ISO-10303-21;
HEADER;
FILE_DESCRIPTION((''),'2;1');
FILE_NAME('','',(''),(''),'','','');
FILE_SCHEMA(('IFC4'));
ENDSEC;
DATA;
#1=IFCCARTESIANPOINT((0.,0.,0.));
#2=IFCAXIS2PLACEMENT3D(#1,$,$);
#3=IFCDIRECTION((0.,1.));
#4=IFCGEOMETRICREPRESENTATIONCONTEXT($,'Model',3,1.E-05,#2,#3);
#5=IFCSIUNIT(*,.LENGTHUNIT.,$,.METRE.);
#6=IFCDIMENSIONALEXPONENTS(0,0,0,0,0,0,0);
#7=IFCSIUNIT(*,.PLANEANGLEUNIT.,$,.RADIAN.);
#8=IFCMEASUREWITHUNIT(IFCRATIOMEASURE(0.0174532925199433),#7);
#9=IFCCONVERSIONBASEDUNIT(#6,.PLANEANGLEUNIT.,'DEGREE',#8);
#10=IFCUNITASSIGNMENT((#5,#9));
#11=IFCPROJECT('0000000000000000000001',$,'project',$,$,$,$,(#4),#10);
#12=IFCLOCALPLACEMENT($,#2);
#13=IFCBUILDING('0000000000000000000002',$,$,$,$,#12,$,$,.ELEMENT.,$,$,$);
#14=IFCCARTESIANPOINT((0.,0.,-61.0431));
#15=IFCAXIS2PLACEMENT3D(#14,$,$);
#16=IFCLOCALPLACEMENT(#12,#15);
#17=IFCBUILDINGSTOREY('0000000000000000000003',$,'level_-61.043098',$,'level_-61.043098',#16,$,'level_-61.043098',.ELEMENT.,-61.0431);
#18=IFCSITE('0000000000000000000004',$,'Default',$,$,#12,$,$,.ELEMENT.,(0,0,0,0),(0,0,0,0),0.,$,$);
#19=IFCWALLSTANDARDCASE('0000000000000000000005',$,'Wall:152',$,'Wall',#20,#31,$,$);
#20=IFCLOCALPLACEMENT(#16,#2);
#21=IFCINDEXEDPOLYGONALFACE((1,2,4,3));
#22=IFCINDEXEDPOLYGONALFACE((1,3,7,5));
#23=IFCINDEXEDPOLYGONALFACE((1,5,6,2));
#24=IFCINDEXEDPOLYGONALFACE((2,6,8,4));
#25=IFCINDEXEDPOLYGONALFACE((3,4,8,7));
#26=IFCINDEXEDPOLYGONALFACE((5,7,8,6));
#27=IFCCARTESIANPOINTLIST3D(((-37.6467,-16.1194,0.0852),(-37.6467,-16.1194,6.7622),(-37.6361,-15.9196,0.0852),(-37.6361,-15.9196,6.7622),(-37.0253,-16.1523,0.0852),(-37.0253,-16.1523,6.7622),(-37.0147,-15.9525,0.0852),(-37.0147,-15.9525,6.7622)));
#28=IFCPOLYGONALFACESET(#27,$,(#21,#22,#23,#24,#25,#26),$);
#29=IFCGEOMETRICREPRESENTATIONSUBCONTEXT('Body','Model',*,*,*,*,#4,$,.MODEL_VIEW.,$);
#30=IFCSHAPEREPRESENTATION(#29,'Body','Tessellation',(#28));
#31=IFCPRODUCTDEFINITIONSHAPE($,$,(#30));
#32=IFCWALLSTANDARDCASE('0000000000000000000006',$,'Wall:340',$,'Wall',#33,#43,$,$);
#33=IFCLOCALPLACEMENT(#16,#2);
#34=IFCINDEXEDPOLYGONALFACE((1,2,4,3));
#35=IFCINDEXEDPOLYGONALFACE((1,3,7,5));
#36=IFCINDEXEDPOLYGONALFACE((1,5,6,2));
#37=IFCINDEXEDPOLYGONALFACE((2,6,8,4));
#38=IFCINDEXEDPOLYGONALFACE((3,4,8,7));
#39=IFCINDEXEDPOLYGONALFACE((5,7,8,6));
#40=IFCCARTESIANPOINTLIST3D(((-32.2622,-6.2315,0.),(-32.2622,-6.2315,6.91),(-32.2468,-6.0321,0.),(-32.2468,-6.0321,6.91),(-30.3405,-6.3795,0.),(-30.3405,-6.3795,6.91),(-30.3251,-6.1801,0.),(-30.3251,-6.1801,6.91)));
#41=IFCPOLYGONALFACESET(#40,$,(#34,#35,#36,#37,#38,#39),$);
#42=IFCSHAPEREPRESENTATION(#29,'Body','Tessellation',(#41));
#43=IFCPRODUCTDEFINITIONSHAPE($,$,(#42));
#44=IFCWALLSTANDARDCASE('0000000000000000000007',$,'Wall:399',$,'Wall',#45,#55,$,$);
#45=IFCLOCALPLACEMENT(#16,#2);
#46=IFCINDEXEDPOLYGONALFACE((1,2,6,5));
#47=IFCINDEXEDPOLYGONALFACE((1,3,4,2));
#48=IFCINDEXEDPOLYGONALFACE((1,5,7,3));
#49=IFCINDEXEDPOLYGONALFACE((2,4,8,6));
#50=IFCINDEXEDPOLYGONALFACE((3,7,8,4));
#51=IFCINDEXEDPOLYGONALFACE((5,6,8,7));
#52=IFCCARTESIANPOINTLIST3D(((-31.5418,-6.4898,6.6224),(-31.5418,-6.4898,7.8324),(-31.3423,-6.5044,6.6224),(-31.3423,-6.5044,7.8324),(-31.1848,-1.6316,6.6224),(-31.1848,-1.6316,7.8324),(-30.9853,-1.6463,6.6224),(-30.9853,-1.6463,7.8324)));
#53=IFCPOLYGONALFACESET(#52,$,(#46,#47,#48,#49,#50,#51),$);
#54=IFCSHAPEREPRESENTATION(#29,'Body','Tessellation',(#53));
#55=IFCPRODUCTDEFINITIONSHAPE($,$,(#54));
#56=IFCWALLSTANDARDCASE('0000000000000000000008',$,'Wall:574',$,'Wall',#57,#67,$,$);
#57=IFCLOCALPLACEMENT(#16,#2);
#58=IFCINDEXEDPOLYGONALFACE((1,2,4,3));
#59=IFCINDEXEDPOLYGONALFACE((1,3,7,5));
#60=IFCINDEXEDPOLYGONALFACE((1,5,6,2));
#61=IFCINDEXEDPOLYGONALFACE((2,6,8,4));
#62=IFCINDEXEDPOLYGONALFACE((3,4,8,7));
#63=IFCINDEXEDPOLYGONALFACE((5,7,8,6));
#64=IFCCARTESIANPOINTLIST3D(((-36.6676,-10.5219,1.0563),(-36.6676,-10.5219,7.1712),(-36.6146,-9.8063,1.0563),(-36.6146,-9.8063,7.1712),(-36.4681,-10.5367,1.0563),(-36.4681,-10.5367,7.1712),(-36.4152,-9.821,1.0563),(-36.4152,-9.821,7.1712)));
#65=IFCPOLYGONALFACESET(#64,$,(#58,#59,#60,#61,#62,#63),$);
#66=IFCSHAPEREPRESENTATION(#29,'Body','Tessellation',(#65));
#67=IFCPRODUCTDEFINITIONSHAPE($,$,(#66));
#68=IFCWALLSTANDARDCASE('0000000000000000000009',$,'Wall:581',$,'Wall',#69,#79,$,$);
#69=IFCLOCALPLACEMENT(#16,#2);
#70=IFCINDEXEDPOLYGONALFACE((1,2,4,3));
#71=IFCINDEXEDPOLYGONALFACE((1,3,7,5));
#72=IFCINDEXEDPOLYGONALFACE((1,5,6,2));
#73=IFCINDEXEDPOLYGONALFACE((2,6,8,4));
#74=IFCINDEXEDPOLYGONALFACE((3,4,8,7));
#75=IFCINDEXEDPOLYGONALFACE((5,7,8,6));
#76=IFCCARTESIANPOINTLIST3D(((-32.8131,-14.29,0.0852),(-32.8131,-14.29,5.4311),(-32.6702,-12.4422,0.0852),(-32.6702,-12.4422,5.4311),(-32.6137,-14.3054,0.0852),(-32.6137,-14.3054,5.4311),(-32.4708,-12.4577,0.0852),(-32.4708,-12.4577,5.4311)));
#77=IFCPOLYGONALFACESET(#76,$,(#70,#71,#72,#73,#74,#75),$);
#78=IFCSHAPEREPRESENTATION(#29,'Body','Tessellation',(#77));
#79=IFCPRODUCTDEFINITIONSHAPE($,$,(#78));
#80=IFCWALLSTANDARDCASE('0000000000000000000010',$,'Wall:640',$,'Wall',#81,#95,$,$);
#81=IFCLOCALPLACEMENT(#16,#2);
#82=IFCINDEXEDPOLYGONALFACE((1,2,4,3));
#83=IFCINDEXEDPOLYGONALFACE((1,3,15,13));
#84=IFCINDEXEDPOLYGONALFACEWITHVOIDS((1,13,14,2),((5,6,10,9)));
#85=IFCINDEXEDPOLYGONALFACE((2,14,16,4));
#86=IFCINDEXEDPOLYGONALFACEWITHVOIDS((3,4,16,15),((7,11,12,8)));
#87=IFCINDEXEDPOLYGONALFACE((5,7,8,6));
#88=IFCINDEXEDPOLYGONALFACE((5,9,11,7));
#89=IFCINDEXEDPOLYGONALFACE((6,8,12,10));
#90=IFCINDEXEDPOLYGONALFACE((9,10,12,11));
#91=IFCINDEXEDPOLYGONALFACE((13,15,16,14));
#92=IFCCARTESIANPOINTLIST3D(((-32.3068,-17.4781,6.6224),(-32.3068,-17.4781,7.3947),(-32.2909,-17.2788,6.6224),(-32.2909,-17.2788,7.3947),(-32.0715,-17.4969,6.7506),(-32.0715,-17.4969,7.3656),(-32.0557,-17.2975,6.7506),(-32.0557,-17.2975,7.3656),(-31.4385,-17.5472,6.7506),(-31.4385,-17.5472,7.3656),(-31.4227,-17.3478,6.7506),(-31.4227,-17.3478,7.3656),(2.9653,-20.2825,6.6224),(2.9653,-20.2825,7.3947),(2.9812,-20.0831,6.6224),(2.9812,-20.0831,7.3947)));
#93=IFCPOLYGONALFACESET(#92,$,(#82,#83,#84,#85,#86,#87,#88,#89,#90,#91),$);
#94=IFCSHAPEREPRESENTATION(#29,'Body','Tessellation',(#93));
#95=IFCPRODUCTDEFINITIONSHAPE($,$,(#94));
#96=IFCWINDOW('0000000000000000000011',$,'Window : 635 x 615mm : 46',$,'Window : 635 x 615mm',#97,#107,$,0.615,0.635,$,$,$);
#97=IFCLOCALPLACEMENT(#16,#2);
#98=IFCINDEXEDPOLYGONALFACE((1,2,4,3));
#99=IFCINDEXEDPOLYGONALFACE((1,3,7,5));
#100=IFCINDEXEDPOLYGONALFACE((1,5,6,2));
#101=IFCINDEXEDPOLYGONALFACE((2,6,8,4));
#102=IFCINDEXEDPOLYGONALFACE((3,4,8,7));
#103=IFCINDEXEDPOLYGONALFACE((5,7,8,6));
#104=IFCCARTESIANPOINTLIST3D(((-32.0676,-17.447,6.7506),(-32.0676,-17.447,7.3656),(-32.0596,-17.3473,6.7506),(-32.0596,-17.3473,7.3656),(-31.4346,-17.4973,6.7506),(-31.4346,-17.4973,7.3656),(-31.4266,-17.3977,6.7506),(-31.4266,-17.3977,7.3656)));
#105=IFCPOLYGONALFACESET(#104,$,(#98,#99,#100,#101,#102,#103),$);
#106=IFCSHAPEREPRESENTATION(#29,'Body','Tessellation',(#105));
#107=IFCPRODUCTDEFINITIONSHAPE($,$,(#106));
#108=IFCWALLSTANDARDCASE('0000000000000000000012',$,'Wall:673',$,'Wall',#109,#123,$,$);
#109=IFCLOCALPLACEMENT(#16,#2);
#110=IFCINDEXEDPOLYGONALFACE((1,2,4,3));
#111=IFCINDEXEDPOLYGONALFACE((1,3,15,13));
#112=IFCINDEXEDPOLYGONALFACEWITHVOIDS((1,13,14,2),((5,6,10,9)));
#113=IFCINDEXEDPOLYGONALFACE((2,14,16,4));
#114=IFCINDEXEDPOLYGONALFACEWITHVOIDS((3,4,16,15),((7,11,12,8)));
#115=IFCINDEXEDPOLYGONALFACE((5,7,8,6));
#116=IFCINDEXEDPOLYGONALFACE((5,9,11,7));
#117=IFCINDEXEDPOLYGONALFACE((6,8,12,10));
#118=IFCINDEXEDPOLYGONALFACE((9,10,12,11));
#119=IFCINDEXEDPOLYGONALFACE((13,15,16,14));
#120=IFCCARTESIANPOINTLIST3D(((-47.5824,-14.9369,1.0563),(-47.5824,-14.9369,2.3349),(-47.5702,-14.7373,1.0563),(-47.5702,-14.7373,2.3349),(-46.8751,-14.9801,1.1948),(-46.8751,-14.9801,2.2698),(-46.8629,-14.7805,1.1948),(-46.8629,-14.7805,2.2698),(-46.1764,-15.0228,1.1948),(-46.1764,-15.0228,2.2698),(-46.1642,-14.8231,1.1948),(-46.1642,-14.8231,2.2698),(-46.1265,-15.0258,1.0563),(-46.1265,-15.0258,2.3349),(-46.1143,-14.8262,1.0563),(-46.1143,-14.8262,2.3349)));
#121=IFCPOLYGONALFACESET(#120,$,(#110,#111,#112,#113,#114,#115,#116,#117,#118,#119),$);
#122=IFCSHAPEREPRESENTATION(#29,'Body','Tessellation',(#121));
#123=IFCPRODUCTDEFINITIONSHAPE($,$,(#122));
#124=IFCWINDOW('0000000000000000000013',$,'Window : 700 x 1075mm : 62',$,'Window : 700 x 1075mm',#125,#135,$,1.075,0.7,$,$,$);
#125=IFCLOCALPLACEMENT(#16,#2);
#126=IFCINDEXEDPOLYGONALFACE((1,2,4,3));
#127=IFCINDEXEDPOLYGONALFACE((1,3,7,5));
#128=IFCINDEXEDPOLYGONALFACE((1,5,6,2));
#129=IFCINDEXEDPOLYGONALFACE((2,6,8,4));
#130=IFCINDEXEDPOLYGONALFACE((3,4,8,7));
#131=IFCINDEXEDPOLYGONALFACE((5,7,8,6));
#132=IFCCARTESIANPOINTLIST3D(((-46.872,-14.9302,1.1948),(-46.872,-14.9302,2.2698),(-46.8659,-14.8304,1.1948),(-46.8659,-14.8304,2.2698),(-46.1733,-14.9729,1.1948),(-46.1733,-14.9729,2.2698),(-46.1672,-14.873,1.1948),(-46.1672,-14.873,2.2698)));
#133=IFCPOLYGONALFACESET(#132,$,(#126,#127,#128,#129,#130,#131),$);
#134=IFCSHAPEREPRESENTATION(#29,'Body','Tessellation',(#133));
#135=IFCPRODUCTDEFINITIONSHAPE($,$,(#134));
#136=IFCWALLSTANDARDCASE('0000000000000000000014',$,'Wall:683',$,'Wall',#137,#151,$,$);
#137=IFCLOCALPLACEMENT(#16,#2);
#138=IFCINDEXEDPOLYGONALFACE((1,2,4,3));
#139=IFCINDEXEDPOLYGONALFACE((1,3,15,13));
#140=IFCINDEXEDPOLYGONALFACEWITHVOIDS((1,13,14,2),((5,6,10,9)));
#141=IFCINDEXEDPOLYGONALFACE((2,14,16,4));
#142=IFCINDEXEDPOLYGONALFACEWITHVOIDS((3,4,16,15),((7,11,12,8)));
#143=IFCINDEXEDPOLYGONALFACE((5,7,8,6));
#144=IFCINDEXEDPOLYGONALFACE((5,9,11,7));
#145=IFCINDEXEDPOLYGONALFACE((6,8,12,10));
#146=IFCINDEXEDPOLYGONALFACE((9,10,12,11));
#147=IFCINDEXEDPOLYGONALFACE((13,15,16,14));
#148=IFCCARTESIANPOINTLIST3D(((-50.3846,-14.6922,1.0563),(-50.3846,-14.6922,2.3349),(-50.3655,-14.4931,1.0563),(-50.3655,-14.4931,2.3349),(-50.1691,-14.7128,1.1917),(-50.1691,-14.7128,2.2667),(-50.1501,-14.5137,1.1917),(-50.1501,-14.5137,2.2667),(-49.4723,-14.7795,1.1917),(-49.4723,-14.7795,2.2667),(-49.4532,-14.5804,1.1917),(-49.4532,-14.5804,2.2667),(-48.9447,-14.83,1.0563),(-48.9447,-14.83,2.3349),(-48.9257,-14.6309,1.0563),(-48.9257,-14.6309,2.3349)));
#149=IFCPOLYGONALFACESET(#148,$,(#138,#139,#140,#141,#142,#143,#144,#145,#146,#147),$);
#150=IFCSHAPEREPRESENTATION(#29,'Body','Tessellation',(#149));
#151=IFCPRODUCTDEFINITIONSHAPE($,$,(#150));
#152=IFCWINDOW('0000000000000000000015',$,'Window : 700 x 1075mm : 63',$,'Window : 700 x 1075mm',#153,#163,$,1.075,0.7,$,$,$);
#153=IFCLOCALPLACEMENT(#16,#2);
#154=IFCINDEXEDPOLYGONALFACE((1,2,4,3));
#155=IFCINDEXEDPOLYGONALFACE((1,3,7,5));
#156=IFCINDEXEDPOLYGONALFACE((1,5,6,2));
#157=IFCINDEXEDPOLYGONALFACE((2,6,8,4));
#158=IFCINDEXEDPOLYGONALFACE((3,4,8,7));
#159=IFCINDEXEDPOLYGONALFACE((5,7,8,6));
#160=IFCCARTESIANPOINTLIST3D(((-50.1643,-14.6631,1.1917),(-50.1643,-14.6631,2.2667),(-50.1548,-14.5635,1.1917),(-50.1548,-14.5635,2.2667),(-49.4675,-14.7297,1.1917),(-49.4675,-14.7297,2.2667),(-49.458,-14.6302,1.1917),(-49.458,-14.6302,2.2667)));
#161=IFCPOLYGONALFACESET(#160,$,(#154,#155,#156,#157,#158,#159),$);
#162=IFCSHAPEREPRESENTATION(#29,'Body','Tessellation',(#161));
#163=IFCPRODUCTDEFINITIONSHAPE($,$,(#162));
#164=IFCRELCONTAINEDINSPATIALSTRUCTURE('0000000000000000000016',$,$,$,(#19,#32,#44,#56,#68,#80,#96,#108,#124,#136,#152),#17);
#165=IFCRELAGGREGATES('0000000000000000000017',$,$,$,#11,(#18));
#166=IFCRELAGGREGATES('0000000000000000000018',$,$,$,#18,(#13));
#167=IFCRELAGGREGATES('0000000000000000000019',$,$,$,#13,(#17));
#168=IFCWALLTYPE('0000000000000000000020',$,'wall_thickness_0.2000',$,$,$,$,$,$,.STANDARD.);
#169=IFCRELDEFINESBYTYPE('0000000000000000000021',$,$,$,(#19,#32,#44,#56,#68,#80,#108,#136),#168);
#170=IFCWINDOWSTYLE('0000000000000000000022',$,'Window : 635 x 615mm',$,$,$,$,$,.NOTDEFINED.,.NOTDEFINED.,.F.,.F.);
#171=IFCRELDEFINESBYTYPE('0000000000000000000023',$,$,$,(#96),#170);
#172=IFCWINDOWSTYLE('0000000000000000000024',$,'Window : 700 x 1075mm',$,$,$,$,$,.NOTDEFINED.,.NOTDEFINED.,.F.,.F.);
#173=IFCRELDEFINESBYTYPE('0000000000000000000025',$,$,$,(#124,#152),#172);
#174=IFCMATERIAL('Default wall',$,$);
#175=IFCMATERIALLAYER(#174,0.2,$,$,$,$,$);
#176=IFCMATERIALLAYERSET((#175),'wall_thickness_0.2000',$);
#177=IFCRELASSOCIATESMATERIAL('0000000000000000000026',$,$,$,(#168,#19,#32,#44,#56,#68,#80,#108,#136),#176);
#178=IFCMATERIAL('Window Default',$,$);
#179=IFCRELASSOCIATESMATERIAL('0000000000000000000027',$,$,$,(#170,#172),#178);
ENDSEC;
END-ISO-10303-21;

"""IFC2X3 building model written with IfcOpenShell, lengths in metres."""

from ifc_helpers import new_model, entity, si_unit, converted_unit, direction, frame, frame_2d, origin, origin_2d_with_axis, place, context, subcontext, project, spatial, polyline, rectangle, outline, extrude, source, transform, mapped, material, layer, layer_set, layer_usage, type_object, type_shapes, element, fill, save


model = new_model("IFC2X3")

# Units and contexts
model_context = context("Model", 3, precision=1e-05, world=origin(), true_north=direction((0.0, 1.0)))
body_context = subcontext(model_context, "Body", "Model", "MODEL_VIEW")
ifc_project = project(units=[si_unit("LENGTHUNIT", "METRE"), converted_unit("PLANEANGLEUNIT", "DEGREE", entity("IfcRatioMeasure", 0.0174532925199433), si_unit("PLANEANGLEUNIT", "RADIAN"), dimensions=[0, 0, 0, 0, 0, 0, 0])], contexts=[model_context])

# Site, building, storey
placement_1 = place(None, origin())
site = spatial("IfcSite", under=ifc_project, at=placement_1, Name="Default", CompositionType="ELEMENT", RefLatitude=(0, 0, 0, 0), RefLongitude=(0, 0, 0, 0), RefElevation=0.0)
building = spatial("IfcBuilding", under=site, at=placement_1, CompositionType="ELEMENT")
storey_placement = place(placement_1, frame((0.0, 0.0, -61.0431)))
storey = spatial("IfcBuildingStorey", under=building, at=storey_placement, Name="level_-61.043098", ObjectType="level_-61.043098", LongName="level_-61.043098", CompositionType="ELEMENT", Elevation=-61.0431)

# Walls
ifc_material_1 = material(Name="Default wall")
ifc_layer = layer(ifc_material_1, 0.2)
ifc_layer_set = layer_set([ifc_layer], Name="wall_thickness_0.2000")
ifc_layer_usage = layer_usage(ifc_layer_set, "AXIS2", "POSITIVE", -0.1)
wall_type = type_object("IfcWallType", Name="wall_thickness_0.2000", PredefinedType="STANDARD", material=ifc_layer_set)
placement_2 = place(placement_1, frame((0.0, 0.0, -60.9579)))
wall_1_placement = place(placement_2, frame((-37.02, -16.0524, 0.0), z_axis=(0.0, 0.0, 1.0), x_axis=(-0.9986, 0.052889, 0.0)))
element("IfcWallStandardCase", 1, at=wall_1_placement, inside=storey, type_object=wall_type, material=ifc_layer_usage, Name="Wall:152", ObjectType="Wall", context=body_context, shape_type="SweptSolid", body=[
    extrude(outline(polyline([(0.6222, -0.1), (0.6222, 0.1), (0.0, 0.1), (0.0, -0.1), (0.6222, -0.1)])), origin(), (0.0, 0.0, 1.0), 6.677),
])
wall_2_placement = place(storey_placement, frame((-30.3328, -6.2798, 0.0), z_axis=(0.0, 0.0, 1.0), x_axis=(-0.997045, 0.076823, 0.0)))
element("IfcWallStandardCase", 2, at=wall_2_placement, inside=storey, type_object=wall_type, material=ifc_layer_usage, Name="Wall:340", ObjectType="Wall", context=body_context, shape_type="SweptSolid", body=[
    extrude(outline(polyline([(1.9275, -0.1), (1.9275, 0.1), (0.0, 0.1), (0.0, -0.1), (1.9275, -0.1)])), origin(), (0.0, 0.0, 1.0), 6.91),
])
placement_3 = place(placement_1, frame((0.0, 0.0, -54.4207)))
wall_3_placement = place(placement_3, frame((-31.442, -6.4971, 0.0), z_axis=(0.0, 0.0, 1.0), x_axis=(0.073288, 0.997311, 0.0)))
element("IfcWallStandardCase", 3, at=wall_3_placement, inside=storey, type_object=wall_type, material=ifc_layer_usage, Name="Wall:399", ObjectType="Wall", context=body_context, shape_type="SweptSolid", body=[
    extrude(outline(polyline([(4.8712, -0.1), (4.8712, 0.1), (0.0, 0.1), (0.0, -0.1), (4.8712, -0.1)])), origin(), (0.0, 0.0, 1.0), 1.21),
])
placement_4 = place(placement_1, frame((0.0, 0.0, -59.9868)))
wall_4_placement = place(placement_4, frame((-36.5149, -9.8137, 0.0), z_axis=(0.0, 0.0, 1.0), x_axis=(-0.073825, -0.997271, 0.0)))
element("IfcWallStandardCase", 4, at=wall_4_placement, inside=storey, type_object=wall_type, material=ifc_layer_usage, Name="Wall:574", ObjectType="Wall", context=body_context, shape_type="SweptSolid", body=[
    extrude(outline(polyline([(0.7176, -0.1), (0.7176, 0.1), (0.0, 0.1), (0.0, -0.1), (0.7176, -0.1)])), origin(), (0.0, 0.0, 1.0), 6.1149),
])
placement_5 = place(placement_1, frame((0.0, 0.0, -60.9579)))
wall_5_placement = place(placement_5, frame((-32.5705, -12.4499, 0.0), z_axis=(0.0, 0.0, 1.0), x_axis=(-0.077129, -0.997021, 0.0)))
element("IfcWallStandardCase", 5, at=wall_5_placement, inside=storey, type_object=wall_type, material=ifc_layer_usage, Name="Wall:581", ObjectType="Wall", context=body_context, shape_type="SweptSolid", body=[
    extrude(outline(polyline([(1.8533, -0.1), (1.8533, 0.1), (0.0, 0.1), (0.0, -0.1), (1.8533, -0.1)])), origin(), (0.0, 0.0, 1.0), 5.3459),
])

# Walls, openings, windows
placement_6 = place(placement_1, frame((0.0, 0.0, -54.4207)))
wall_6_placement = place(placement_6, frame((-32.2989, -17.3785, 0.0), z_axis=(0.0, 0.0, 1.0), x_axis=(0.996854, -0.079255, 0.0)))
wall_6 = element("IfcWallStandardCase", 6, at=wall_6_placement, inside=storey, type_object=wall_type, material=ifc_layer_usage, Name="Wall:640", ObjectType="Wall", context=body_context, shape_type="SweptSolid", body=[
    extrude(outline(polyline([(35.3834, -0.1), (35.3834, 0.1), (0.0, 0.1), (0.0, -0.1), (35.3834, -0.1)])), origin(), (0.0, 0.0, 1.0), 0.7723),
])
opening_1_placement = place(wall_6_placement, frame((0.236, -0.1, 0.1282)))
opening_1 = element("IfcOpeningElement", 7, at=opening_1_placement, cuts=wall_6, ObjectType="Opening", context=body_context, shape_type="SweptSolid", body=[
    extrude(rectangle(XDim=0.635, YDim=0.615, at=frame_2d((0.3075, 0.3175), x_axis=(0.0, 1.0))), frame((0.0, 0.0, 0.0), z_axis=(0.0, 1.0, 0.0), x_axis=(0.0, 0.0, 1.0)), (0.0, 0.0, 1.0), 0.2),
])
ifc_material_2 = material(Name="Window Default")
window_style_1 = type_object("IfcWindowStyle", Name="Window : 635 x 615mm", ConstructionType="NOTDEFINED", OperationType="NOTDEFINED", ParameterTakesPrecedence=False, Sizeable=False, material=ifc_material_2)
shared_shape_1 = source(origin(), body_context, "Body", "SweptSolid", [
    extrude(rectangle(XDim=0.1, YDim=0.635, at=origin_2d_with_axis()), frame((0.3175, 0.1, 0.0), z_axis=(0.0, 0.0, 1.0), x_axis=(0.0, 1.0, 0.0)), (0.0, 0.0, 1.0), 0.615),
])
type_shapes(window_style_1, [shared_shape_1])
window_1_placement = place(opening_1_placement, origin())
window_1 = element("IfcWindow", 8, at=window_1_placement, inside=storey, type_object=window_style_1, Name="Window : 635 x 615mm : 46", ObjectType="Window : 635 x 615mm", OverallHeight=0.615, OverallWidth=0.635, context=body_context, shape_type="MappedRepresentation", body=[
    mapped(shared_shape_1, transform((0.0, 0.0, 0.0), scale=1.0)),
])
fill(opening_1, window_1)
placement_7 = place(placement_1, frame((0.0, 0.0, -59.9868)))
wall_7_placement = place(placement_7, frame((-46.1204, -14.926, 0.0), z_axis=(0.0, 0.0, 1.0), x_axis=(-0.99814, 0.06096, 0.0)))
wall_7 = element("IfcWallStandardCase", 9, at=wall_7_placement, inside=storey, type_object=wall_type, material=ifc_layer_usage, Name="Wall:673", ObjectType="Wall", context=body_context, shape_type="SweptSolid", body=[
    extrude(outline(polyline([(1.4586, -0.1), (1.4586, 0.1), (0.0, 0.1), (0.0, -0.1), (1.4586, -0.1)])), origin(), (0.0, 0.0, 1.0), 1.2785),
])
opening_2_placement = place(wall_7_placement, frame((0.05, -0.1, 0.1385)))
opening_2 = element("IfcOpeningElement", 10, at=opening_2_placement, cuts=wall_7, ObjectType="Opening", context=body_context, shape_type="SweptSolid", body=[
    extrude(rectangle(XDim=0.7, YDim=1.075, at=frame_2d((0.5375, 0.35), x_axis=(0.0, 1.0))), frame((0.0, 0.0, 0.0), z_axis=(0.0, 1.0, 0.0), x_axis=(0.0, 0.0, 1.0)), (0.0, 0.0, 1.0), 0.2),
])
window_style_2 = type_object("IfcWindowStyle", Name="Window : 700 x 1075mm", ConstructionType="NOTDEFINED", OperationType="NOTDEFINED", ParameterTakesPrecedence=False, Sizeable=False, material=ifc_material_2)
shared_shape_2 = source(origin(), body_context, "Body", "SweptSolid", [
    extrude(rectangle(XDim=0.1, YDim=0.7, at=origin_2d_with_axis()), frame((0.35, 0.1, 0.0), z_axis=(0.0, 0.0, 1.0), x_axis=(0.0, 1.0, 0.0)), (0.0, 0.0, 1.0), 1.075),
])
type_shapes(window_style_2, [shared_shape_2])
window_2_placement = place(opening_2_placement, origin())
window_2 = element("IfcWindow", 11, at=window_2_placement, inside=storey, type_object=window_style_2, Name="Window : 700 x 1075mm : 62", ObjectType="Window : 700 x 1075mm", OverallHeight=1.075, OverallWidth=0.7, context=body_context, shape_type="MappedRepresentation", body=[
    mapped(shared_shape_2, transform((0.0, 0.0, 0.0), scale=1.0)),
])
fill(opening_2, window_2)
placement_8 = place(placement_1, frame((0.0, 0.0, -59.9868)))
wall_8_placement = place(placement_8, frame((-48.9352, -14.7304, 0.0), z_axis=(0.0, 0.0, 1.0), x_axis=(-0.995454, 0.095244, 0.0)))
wall_8 = element("IfcWallStandardCase", 12, at=wall_8_placement, inside=storey, type_object=wall_type, material=ifc_layer_usage, Name="Wall:683", ObjectType="Wall", context=body_context, shape_type="SweptSolid", body=[
    extrude(outline(polyline([(1.4464, -0.1), (1.4464, 0.1), (0.0, 0.1), (0.0, -0.1), (1.4464, -0.1)])), origin(), (0.0, 0.0, 1.0), 1.2785),
])
opening_3_placement = place(wall_8_placement, frame((0.53, -0.1, 0.1354)))
opening_3 = element("IfcOpeningElement", 13, at=opening_3_placement, cuts=wall_8, ObjectType="Opening", context=body_context, shape_type="SweptSolid", body=[
    extrude(rectangle(XDim=0.7, YDim=1.075, at=frame_2d((0.5375, 0.35), x_axis=(0.0, 1.0))), frame((0.0, 0.0, 0.0), z_axis=(0.0, 1.0, 0.0), x_axis=(0.0, 0.0, 1.0)), (0.0, 0.0, 1.0), 0.2),
])
window_3_placement = place(opening_3_placement, origin())
window_3 = element("IfcWindow", 14, at=window_3_placement, inside=storey, type_object=window_style_2, Name="Window : 700 x 1075mm : 63", ObjectType="Window : 700 x 1075mm", OverallHeight=1.075, OverallWidth=0.7, context=body_context, shape_type="MappedRepresentation", body=[
    mapped(shared_shape_2, transform((0.0, 0.0, 0.0), scale=1.0)),
])
fill(opening_3, window_3)

save(model, "model.ifc")
